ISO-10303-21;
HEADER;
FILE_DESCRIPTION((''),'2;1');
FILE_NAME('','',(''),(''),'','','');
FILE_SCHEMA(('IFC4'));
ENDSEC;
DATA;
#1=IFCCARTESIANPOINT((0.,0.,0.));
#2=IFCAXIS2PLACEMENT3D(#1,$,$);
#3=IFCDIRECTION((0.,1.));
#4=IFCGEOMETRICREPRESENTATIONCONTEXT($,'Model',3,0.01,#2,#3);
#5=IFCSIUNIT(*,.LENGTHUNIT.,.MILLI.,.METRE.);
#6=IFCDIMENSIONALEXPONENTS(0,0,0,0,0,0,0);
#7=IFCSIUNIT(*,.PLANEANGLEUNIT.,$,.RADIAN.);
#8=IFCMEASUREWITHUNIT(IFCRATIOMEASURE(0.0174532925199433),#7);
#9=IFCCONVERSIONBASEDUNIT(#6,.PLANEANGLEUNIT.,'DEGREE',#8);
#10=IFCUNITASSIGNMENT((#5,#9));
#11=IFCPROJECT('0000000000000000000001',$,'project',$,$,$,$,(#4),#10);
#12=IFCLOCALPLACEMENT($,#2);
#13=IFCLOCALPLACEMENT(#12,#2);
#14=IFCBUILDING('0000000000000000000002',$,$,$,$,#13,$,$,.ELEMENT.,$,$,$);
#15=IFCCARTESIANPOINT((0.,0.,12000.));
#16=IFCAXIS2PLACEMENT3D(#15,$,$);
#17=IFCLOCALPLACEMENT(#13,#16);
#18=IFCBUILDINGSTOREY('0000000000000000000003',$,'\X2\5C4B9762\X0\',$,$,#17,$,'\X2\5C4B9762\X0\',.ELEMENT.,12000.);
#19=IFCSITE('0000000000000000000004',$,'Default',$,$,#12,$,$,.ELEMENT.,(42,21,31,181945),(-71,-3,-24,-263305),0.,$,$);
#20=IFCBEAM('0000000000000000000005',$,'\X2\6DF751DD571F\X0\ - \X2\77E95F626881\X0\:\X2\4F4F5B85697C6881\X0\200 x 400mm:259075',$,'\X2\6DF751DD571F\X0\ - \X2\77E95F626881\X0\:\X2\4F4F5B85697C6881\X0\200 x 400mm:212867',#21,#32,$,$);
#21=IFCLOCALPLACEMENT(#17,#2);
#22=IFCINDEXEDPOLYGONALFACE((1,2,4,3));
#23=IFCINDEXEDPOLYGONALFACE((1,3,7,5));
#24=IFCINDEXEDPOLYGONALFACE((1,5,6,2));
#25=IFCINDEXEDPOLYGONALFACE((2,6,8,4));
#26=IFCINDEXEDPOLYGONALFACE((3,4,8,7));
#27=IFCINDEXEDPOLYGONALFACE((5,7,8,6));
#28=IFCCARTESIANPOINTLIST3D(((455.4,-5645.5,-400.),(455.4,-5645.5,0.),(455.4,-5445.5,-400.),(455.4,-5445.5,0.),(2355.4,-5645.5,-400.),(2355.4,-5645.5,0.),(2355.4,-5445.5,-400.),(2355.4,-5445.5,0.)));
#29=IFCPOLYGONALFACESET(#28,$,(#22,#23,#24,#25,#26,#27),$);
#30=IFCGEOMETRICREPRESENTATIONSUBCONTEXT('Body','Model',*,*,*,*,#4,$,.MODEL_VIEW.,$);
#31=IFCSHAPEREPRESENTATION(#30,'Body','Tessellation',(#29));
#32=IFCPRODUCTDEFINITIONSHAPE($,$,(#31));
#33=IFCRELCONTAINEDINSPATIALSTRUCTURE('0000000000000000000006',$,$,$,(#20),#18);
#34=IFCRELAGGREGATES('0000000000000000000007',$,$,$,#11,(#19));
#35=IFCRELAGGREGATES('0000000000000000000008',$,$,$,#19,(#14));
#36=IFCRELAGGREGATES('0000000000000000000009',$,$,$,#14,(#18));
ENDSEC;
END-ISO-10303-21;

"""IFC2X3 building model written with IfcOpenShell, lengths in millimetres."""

from ifc_helpers import new_model, entity, si_unit, converted_unit, direction, frame, frame_2d, origin, place, context, subcontext, project, spatial, rectangle, extrude, element, save


model = new_model("IFC2X3")

# Units and contexts
model_context = context("Model", 3, precision=0.01, world=origin(), true_north=direction((0.0, 1.0)))
body_context = subcontext(model_context, "Body", "Model", "MODEL_VIEW")
ifc_project = project(units=[si_unit("LENGTHUNIT", "METRE", prefix="MILLI"), converted_unit("PLANEANGLEUNIT", "DEGREE", entity("IfcRatioMeasure", 0.0174532925199433), si_unit("PLANEANGLEUNIT", "RADIAN"), dimensions=[0, 0, 0, 0, 0, 0, 0])], contexts=[model_context])

# Site, building, storey
site_placement = place(None, origin())
site = spatial("IfcSite", under=ifc_project, at=site_placement, Name="Default", CompositionType="ELEMENT", RefLatitude=(42, 21, 31, 181945), RefLongitude=(-71, -3, -24, -263305), RefElevation=0.0)
building_placement = place(site_placement, origin())
building = spatial("IfcBuilding", under=site, at=building_placement, CompositionType="ELEMENT")
storey_placement = place(building_placement, frame((0.0, 0.0, 12000.0)))
storey = spatial("IfcBuildingStorey", under=building, at=storey_placement, Name="屋面", LongName="屋面", CompositionType="ELEMENT", Elevation=12000.0)

# Beam
beam_placement = place(storey_placement, frame((2455.4, -5545.5, 0.0), z_axis=(0.0, 0.0, 1.0), x_axis=(-1.0, 0.0, 0.0)))
element("IfcBeam", 1, at=beam_placement, inside=storey, Name="混凝土 - 矩形梁:住宅楼梁200 x 400mm:259075", ObjectType="混凝土 - 矩形梁:住宅楼梁200 x 400mm:212867", context=body_context, shape_type="SweptSolid", body=[
    extrude(rectangle(XDim=400.0, YDim=200.0, at=frame_2d((0.0, 0.0), x_axis=(1.0, 0.0))), frame((100.0, 0.0, -200.0), z_axis=(1.0, 0.0, 0.0), x_axis=(0.0, 0.0, -1.0)), (0.0, 0.0, 1.0), 1900.0),
])

save(model, "model.ifc")
